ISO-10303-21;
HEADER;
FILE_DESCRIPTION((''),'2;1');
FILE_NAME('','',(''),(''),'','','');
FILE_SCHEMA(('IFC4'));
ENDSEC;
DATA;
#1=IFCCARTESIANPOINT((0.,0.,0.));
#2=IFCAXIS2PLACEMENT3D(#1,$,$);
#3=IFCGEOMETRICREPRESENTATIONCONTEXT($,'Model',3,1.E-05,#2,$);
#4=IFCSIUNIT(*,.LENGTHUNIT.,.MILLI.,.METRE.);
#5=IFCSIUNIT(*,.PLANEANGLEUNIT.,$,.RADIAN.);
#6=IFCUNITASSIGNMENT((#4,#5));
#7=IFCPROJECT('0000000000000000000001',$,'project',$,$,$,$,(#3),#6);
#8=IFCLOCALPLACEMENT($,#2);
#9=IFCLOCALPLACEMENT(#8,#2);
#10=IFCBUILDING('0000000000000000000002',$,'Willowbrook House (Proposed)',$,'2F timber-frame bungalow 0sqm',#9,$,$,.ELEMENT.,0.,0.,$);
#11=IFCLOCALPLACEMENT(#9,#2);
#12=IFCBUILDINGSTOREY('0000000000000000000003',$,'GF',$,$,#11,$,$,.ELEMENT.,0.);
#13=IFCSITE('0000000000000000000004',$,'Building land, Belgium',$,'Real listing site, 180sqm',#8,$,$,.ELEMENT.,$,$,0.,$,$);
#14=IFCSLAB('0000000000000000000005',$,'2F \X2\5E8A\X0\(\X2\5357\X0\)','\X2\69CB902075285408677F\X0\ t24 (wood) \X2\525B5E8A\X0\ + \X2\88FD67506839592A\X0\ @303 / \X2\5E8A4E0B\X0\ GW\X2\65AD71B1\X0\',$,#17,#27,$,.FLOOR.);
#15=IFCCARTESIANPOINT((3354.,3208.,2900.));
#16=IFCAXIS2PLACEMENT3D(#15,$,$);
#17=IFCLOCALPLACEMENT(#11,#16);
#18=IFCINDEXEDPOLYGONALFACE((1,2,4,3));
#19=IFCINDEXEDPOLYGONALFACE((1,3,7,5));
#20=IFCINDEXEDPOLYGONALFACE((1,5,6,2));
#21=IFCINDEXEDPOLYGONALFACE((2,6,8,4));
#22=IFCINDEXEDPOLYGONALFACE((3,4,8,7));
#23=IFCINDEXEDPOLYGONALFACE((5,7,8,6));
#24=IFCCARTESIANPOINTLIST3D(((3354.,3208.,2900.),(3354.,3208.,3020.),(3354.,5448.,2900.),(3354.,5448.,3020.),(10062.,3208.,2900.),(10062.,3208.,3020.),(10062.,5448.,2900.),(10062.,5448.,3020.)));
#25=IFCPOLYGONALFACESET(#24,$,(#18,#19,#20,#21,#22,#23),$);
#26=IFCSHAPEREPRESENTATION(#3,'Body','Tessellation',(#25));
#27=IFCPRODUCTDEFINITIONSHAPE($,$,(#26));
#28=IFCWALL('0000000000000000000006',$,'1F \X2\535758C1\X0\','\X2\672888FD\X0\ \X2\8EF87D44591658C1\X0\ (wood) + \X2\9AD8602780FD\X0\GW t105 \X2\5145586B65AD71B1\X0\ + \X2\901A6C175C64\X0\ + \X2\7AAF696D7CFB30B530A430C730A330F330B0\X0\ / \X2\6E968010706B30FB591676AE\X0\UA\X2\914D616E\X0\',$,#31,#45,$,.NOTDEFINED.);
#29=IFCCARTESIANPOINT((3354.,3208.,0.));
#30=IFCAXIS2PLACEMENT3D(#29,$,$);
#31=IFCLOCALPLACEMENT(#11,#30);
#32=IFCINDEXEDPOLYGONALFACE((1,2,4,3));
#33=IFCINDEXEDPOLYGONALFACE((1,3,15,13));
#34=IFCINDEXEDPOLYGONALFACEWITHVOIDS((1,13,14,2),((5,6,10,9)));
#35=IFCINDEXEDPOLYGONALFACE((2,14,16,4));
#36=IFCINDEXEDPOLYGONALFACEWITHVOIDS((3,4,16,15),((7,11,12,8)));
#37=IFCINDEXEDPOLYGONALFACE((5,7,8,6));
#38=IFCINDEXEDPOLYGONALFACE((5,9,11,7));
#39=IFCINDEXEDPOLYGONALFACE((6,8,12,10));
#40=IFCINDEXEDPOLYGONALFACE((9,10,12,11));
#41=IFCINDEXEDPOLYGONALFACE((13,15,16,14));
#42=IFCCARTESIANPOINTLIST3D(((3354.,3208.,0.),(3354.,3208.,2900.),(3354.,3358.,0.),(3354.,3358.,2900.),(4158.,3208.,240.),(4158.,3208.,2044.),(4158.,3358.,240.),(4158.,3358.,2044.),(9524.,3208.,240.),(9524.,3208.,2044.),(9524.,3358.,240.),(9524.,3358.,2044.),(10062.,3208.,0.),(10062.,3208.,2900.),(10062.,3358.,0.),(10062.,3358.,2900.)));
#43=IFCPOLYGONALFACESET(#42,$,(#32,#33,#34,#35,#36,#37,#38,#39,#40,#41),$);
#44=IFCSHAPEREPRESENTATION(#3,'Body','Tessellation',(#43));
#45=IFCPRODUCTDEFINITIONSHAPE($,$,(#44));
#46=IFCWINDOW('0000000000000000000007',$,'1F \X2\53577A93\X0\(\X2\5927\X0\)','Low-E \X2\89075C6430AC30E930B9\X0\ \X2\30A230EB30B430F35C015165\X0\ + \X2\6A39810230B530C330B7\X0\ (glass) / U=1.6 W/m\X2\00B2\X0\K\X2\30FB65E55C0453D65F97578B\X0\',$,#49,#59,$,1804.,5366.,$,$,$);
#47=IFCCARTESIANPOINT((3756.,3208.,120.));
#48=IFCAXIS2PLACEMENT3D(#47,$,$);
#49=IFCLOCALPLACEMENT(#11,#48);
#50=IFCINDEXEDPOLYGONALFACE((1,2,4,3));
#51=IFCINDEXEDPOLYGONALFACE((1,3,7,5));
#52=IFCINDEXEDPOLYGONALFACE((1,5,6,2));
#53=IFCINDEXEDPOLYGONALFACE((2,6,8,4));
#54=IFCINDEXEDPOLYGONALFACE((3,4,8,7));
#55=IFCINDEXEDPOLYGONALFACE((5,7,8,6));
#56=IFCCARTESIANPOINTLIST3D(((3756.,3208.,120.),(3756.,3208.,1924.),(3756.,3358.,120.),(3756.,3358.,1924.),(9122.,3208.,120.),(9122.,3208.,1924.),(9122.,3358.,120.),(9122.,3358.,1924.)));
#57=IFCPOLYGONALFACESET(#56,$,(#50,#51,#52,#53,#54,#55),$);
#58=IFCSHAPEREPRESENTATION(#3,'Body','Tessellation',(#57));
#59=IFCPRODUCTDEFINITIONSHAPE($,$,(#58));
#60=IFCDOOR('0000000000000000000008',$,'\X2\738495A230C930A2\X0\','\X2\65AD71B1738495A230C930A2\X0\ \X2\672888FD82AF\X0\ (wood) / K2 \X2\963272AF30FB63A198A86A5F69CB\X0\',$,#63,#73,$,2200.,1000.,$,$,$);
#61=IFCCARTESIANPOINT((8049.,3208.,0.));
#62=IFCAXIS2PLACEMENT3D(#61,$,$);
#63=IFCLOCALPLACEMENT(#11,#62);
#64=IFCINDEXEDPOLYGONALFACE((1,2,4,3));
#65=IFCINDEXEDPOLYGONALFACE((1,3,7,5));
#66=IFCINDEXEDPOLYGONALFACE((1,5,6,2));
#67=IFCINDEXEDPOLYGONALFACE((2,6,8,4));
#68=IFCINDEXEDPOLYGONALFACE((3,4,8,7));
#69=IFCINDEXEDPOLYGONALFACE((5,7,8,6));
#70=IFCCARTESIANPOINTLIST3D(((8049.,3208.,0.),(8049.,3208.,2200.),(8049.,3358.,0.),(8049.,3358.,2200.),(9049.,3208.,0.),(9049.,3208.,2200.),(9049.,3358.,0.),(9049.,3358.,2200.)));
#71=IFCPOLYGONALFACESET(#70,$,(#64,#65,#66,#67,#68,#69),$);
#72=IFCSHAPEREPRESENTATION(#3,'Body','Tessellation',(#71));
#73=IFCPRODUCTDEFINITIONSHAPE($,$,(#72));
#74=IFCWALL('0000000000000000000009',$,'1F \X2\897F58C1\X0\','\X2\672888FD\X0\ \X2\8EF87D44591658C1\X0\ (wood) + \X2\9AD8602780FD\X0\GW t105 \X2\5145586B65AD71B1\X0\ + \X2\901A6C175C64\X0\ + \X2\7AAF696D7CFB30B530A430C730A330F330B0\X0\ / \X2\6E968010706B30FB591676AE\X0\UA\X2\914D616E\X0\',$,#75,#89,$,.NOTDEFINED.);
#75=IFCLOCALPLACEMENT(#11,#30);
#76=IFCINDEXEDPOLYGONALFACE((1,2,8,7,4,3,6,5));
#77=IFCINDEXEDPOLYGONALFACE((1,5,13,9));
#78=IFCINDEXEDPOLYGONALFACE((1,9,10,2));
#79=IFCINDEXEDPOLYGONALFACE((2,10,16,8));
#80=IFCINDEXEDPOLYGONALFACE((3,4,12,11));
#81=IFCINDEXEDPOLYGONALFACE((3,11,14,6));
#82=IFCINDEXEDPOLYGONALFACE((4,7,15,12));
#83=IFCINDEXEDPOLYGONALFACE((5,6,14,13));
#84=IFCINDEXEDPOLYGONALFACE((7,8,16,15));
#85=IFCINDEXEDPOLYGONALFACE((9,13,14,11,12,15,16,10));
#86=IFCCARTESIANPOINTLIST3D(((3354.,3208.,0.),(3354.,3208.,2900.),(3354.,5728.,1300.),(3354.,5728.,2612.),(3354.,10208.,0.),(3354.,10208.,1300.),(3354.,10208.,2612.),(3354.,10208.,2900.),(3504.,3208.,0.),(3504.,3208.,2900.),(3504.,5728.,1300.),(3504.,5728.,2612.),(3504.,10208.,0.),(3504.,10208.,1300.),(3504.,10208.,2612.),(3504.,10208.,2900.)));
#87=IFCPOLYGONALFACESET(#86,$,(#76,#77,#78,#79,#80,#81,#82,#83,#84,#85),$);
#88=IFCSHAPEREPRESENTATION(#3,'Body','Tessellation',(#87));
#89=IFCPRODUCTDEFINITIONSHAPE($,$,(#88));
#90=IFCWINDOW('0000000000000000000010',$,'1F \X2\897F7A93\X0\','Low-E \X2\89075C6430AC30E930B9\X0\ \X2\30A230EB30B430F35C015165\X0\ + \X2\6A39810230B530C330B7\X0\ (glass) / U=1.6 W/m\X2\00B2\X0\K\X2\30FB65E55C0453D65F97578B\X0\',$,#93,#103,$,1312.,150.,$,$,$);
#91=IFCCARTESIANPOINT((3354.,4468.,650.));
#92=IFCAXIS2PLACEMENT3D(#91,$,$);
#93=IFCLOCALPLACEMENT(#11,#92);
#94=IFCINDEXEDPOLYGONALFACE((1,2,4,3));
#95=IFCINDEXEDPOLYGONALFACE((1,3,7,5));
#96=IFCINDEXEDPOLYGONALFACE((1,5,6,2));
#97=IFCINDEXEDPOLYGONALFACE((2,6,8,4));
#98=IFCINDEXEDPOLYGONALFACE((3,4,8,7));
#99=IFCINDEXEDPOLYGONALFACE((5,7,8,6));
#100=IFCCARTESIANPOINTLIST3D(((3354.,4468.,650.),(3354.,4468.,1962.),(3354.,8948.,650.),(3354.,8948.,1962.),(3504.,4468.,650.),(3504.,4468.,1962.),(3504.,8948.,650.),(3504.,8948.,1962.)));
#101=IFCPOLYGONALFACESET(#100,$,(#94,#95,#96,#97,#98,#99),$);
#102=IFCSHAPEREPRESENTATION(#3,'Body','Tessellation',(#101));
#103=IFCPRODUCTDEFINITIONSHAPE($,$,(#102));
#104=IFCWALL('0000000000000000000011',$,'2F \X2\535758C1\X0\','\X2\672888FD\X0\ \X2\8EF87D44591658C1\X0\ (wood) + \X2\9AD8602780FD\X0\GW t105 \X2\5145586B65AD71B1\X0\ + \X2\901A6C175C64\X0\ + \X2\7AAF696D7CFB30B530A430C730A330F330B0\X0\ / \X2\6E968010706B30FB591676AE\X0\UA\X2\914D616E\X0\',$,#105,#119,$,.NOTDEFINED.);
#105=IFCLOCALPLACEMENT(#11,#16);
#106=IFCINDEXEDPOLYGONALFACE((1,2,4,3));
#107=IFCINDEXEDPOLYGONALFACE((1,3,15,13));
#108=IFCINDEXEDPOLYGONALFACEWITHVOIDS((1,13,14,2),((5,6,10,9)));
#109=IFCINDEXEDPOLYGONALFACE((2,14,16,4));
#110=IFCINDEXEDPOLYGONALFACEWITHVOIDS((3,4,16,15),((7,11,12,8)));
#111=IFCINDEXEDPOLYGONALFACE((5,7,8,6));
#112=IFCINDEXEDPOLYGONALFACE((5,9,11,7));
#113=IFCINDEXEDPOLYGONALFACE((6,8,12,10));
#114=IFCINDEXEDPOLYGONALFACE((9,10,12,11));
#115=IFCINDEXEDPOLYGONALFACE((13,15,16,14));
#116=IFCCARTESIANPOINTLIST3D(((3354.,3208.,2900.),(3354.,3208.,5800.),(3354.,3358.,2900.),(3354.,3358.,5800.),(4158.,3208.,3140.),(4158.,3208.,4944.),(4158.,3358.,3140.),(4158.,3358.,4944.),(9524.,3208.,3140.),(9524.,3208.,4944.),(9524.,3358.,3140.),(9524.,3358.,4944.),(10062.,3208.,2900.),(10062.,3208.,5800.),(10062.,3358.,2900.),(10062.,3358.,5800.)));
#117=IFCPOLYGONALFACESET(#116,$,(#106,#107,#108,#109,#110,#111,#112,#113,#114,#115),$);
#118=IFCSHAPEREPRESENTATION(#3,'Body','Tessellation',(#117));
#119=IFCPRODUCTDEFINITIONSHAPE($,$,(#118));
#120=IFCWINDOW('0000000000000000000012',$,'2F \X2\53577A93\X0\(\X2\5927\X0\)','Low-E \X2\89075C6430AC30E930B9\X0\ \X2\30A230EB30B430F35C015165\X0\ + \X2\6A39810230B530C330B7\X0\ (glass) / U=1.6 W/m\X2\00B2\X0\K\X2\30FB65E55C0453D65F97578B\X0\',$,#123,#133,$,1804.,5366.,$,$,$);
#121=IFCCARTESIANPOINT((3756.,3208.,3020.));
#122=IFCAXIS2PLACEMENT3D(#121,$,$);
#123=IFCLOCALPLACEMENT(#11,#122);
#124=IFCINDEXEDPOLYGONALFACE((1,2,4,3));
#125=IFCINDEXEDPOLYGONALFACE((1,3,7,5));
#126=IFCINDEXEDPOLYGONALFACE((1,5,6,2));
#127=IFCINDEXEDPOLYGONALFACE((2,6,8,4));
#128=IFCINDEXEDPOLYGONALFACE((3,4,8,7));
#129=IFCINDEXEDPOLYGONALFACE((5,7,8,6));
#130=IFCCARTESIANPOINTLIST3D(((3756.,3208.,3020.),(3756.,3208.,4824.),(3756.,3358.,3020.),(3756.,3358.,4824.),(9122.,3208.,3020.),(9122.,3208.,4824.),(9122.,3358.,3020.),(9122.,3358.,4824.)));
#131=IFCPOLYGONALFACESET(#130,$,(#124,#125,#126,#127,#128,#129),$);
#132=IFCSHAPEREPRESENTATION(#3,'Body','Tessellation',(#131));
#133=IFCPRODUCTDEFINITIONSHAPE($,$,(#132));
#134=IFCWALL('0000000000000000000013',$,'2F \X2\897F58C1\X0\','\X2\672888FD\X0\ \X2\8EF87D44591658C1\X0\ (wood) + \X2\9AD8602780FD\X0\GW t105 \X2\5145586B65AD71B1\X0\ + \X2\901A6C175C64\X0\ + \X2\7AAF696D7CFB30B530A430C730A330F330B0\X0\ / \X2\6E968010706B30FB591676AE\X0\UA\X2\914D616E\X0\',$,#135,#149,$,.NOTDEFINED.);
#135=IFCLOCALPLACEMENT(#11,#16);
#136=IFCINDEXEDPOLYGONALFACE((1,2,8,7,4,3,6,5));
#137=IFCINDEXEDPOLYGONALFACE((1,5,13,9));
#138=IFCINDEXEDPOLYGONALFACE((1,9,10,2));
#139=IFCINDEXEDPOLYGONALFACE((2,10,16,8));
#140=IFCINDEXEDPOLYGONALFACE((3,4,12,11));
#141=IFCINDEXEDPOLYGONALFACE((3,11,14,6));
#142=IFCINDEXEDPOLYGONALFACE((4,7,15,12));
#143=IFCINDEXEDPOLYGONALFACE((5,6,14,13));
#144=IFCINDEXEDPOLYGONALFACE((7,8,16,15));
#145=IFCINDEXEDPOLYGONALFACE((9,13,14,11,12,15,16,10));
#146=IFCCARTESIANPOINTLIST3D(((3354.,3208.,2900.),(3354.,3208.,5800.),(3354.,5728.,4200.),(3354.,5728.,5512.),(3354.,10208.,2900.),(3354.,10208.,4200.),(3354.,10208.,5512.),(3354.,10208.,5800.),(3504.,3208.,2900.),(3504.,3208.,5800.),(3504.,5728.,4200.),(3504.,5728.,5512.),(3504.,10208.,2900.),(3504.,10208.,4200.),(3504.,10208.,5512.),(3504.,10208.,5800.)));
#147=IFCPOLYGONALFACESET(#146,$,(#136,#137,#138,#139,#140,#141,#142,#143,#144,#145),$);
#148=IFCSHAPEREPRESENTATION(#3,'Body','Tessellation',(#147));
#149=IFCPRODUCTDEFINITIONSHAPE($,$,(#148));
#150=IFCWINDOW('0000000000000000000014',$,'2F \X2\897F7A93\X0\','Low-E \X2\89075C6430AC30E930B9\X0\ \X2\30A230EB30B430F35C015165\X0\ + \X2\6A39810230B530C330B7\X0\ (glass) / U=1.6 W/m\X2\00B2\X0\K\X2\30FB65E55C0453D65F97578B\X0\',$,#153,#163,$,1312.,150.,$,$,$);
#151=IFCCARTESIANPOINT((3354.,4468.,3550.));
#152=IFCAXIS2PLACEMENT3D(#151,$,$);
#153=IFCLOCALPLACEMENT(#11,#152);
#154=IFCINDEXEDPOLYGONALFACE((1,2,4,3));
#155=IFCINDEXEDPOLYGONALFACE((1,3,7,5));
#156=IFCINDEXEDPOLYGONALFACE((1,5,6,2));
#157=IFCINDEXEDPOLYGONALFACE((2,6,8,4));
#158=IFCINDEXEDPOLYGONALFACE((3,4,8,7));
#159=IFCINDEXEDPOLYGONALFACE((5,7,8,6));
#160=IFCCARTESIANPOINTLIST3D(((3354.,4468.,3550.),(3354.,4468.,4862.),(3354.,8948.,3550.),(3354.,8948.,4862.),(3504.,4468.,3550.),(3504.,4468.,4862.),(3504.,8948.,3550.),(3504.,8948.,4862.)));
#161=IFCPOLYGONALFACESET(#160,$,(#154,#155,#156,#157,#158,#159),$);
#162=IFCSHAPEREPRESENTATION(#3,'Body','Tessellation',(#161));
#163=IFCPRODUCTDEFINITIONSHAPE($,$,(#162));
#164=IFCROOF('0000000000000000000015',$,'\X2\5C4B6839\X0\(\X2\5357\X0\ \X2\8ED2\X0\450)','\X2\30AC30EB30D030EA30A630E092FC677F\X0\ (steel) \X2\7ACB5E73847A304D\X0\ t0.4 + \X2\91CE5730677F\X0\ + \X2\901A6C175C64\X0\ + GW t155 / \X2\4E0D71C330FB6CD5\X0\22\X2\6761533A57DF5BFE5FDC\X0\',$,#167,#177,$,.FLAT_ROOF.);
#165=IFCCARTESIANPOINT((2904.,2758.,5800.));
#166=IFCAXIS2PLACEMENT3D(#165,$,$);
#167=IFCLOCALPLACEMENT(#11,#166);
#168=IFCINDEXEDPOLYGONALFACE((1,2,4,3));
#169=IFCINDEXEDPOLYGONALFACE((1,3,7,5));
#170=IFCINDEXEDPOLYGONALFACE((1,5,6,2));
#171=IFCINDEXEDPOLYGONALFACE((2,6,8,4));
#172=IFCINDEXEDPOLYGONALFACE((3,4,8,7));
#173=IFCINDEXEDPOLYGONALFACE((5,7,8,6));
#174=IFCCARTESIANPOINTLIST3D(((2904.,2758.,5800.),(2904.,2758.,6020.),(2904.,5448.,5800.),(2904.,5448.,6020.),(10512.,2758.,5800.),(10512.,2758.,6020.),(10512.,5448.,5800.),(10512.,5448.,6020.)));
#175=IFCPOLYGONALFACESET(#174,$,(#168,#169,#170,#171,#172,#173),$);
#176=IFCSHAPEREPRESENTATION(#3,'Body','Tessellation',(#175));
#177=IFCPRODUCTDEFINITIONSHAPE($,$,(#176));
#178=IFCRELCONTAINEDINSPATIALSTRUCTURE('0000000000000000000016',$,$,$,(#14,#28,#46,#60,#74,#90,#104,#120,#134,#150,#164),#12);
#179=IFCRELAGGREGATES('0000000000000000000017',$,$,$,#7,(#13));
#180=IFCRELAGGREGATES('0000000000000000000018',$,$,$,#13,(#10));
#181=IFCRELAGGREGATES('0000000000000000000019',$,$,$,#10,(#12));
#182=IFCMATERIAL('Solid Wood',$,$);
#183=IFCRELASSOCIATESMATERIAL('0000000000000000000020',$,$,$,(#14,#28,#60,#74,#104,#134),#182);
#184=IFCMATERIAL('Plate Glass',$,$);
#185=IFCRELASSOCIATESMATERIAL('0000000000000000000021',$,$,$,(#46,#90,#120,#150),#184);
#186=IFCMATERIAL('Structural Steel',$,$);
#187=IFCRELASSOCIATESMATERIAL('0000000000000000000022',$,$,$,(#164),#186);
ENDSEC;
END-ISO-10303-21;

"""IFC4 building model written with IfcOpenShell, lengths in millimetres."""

from ifc_helpers import new_model, si_unit, frame, frame_2d, origin, place, context, project, spatial, rectangle, extrude, material, element, fill, save


model = new_model("IFC4")

# Units and contexts
model_context = context("Model", 3, precision=1e-05, world=origin())
ifc_project = project(units=[si_unit("LENGTHUNIT", "METRE", prefix="MILLI"), si_unit("PLANEANGLEUNIT", "RADIAN")], contexts=[model_context])

# Site, building, storey
site_placement = place(None, origin())
site = spatial("IfcSite", under=ifc_project, at=site_placement, Name="Building land, Belgium", ObjectType="Real listing site, 180sqm", CompositionType="ELEMENT", RefElevation=0.0)
building_placement = place(site_placement, origin())
building = spatial("IfcBuilding", under=site, at=building_placement, Name="Willowbrook House (Proposed)", ObjectType="2F timber-frame bungalow 0sqm", CompositionType="ELEMENT", ElevationOfRefHeight=0.0, ElevationOfTerrain=0.0)
storey_placement = place(building_placement, origin())
storey = spatial("IfcBuildingStorey", under=building, at=storey_placement, Name="GF", CompositionType="ELEMENT", Elevation=0.0)

# Slab
ifc_material_1 = material(Name="Solid Wood")
slab_1_placement = place(storey_placement, frame((3354.0, 3208.0, 2900.0)))
element("IfcSlab", 1, at=slab_1_placement, inside=storey, material=ifc_material_1, Name="2F 床(南)", Description="構造用合板 t24 (wood) 剛床 + 製材根太 @303 / 床下 GW断熱", PredefinedType="FLOOR", context=model_context, shape_type="SweptSolid", body=[
    extrude(rectangle(XDim=6708.0, YDim=2240.0, at=frame_2d((3354.0, 1120.0))), frame((3354.0, 3208.0, 2900.0)), (0.0, 0.0, 1.0), 120.0),
])

# Wall, openings, window, door
wall_1_placement = place(storey_placement, frame((3354.0, 3208.0, 0.0)))
wall_1 = element("IfcWall", 2, at=wall_1_placement, inside=storey, material=ifc_material_1, Name="1F 南壁", Description="木製 軸組外壁 (wood) + 高性能GW t105 充填断熱 + 通気層 + 窯業系サイディング / 準耐火・外皮UA配慮", PredefinedType="NOTDEFINED", context=model_context, shape_type="SweptSolid", body=[
    extrude(rectangle(XDim=6708.0, YDim=150.0, at=frame_2d((3354.0, 75.0))), frame((3354.0, 3208.0, 0.0)), (0.0, 0.0, 1.0), 2900.0),
])
opening_1_placement = place(storey_placement, frame((3756.0, 3208.0, 120.0)))
opening_1 = element("IfcOpeningElement", 3, at=opening_1_placement, cuts=wall_1, PredefinedType="NOTDEFINED", context=model_context, shape_type="SweptSolid", body=[
    extrude(rectangle(XDim=5366.0, YDim=150.0, at=frame_2d((2683.0, 75.0))), frame((3756.0, 3208.0, 120.0)), (0.0, 0.0, 1.0), 1804.0),
])
opening_2_placement = place(storey_placement, frame((8049.0, 3208.0, 0.0)))
opening_2 = element("IfcOpeningElement", 4, at=opening_2_placement, cuts=wall_1, PredefinedType="NOTDEFINED", context=model_context, shape_type="SweptSolid", body=[
    extrude(rectangle(XDim=1000.0, YDim=150.0, at=frame_2d((500.0, 75.0))), frame((8049.0, 3208.0, 0.0)), (0.0, 0.0, 1.0), 2200.0),
])
ifc_material_2 = material(Name="Plate Glass")
window_1_placement = place(storey_placement, frame((3756.0, 3208.0, 120.0)))
window_1 = element("IfcWindow", 5, at=window_1_placement, inside=storey, material=ifc_material_2, Name="1F 南窓(大)", Description="Low-E 複層ガラス アルゴン封入 + 樹脂サッシ (glass) / U=1.6 W/m²K・日射取得型", OverallHeight=1804.0, OverallWidth=5366.0, context=model_context, shape_type="SweptSolid", body=[
    extrude(rectangle(XDim=5366.0, YDim=150.0, at=frame_2d((2683.0, 75.0))), frame((3756.0, 3208.0, 120.0)), (0.0, 0.0, 1.0), 1804.0),
])
fill(opening_1, window_1)
door_placement = place(storey_placement, frame((8049.0, 3208.0, 0.0)))
door = element("IfcDoor", 6, at=door_placement, inside=storey, material=ifc_material_1, Name="玄関ドア", Description="断熱玄関ドア 木製芯 (wood) / K2 防犯・採風機構", OverallHeight=2200.0, OverallWidth=1000.0, context=model_context, shape_type="SweptSolid", body=[
    extrude(rectangle(XDim=1000.0, YDim=150.0, at=frame_2d((500.0, 75.0))), frame((8049.0, 3208.0, 0.0)), (0.0, 0.0, 1.0), 2200.0),
])
fill(opening_2, door)

# Walls, openings, windows
wall_2_placement = place(storey_placement, frame((3354.0, 3208.0, 0.0)))
wall_2 = element("IfcWall", 7, at=wall_2_placement, inside=storey, material=ifc_material_1, Name="1F 西壁", Description="木製 軸組外壁 (wood) + 高性能GW t105 充填断熱 + 通気層 + 窯業系サイディング / 準耐火・外皮UA配慮", PredefinedType="NOTDEFINED", context=model_context, shape_type="SweptSolid", body=[
    extrude(rectangle(XDim=150.0, YDim=7000.0, at=frame_2d((75.0, 3500.0))), frame((3354.0, 3208.0, 0.0)), (0.0, 0.0, 1.0), 2900.0),
])
opening_3_placement = place(storey_placement, frame((3354.0, 4468.0, 650.0)))
opening_3 = element("IfcOpeningElement", 8, at=opening_3_placement, cuts=wall_2, PredefinedType="NOTDEFINED", context=model_context, shape_type="SweptSolid", body=[
    extrude(rectangle(XDim=150.0, YDim=4480.0, at=frame_2d((75.0, 2240.0))), frame((3354.0, 4468.0, 650.0)), (0.0, 0.0, 1.0), 1312.0),
])
window_2_placement = place(storey_placement, frame((3354.0, 4468.0, 650.0)))
window_2 = element("IfcWindow", 9, at=window_2_placement, inside=storey, material=ifc_material_2, Name="1F 西窓", Description="Low-E 複層ガラス アルゴン封入 + 樹脂サッシ (glass) / U=1.6 W/m²K・日射取得型", OverallHeight=1312.0, OverallWidth=150.0, context=model_context, shape_type="SweptSolid", body=[
    extrude(rectangle(XDim=150.0, YDim=4480.0, at=frame_2d((75.0, 2240.0))), frame((3354.0, 4468.0, 650.0)), (0.0, 0.0, 1.0), 1312.0),
])
fill(opening_3, window_2)
wall_3_placement = place(storey_placement, frame((3354.0, 3208.0, 2900.0)))
wall_3 = element("IfcWall", 10, at=wall_3_placement, inside=storey, material=ifc_material_1, Name="2F 南壁", Description="木製 軸組外壁 (wood) + 高性能GW t105 充填断熱 + 通気層 + 窯業系サイディング / 準耐火・外皮UA配慮", PredefinedType="NOTDEFINED", context=model_context, shape_type="SweptSolid", body=[
    extrude(rectangle(XDim=6708.0, YDim=150.0, at=frame_2d((3354.0, 75.0))), frame((3354.0, 3208.0, 2900.0)), (0.0, 0.0, 1.0), 2900.0),
])
opening_4_placement = place(storey_placement, frame((3756.0, 3208.0, 3020.0)))
opening_4 = element("IfcOpeningElement", 11, at=opening_4_placement, cuts=wall_3, PredefinedType="NOTDEFINED", context=model_context, shape_type="SweptSolid", body=[
    extrude(rectangle(XDim=5366.0, YDim=150.0, at=frame_2d((2683.0, 75.0))), frame((3756.0, 3208.0, 3020.0)), (0.0, 0.0, 1.0), 1804.0),
])
window_3_placement = place(storey_placement, frame((3756.0, 3208.0, 3020.0)))
window_3 = element("IfcWindow", 12, at=window_3_placement, inside=storey, material=ifc_material_2, Name="2F 南窓(大)", Description="Low-E 複層ガラス アルゴン封入 + 樹脂サッシ (glass) / U=1.6 W/m²K・日射取得型", OverallHeight=1804.0, OverallWidth=5366.0, context=model_context, shape_type="SweptSolid", body=[
    extrude(rectangle(XDim=5366.0, YDim=150.0, at=frame_2d((2683.0, 75.0))), frame((3756.0, 3208.0, 3020.0)), (0.0, 0.0, 1.0), 1804.0),
])
fill(opening_4, window_3)
wall_4_placement = place(storey_placement, frame((3354.0, 3208.0, 2900.0)))
wall_4 = element("IfcWall", 13, at=wall_4_placement, inside=storey, material=ifc_material_1, Name="2F 西壁", Description="木製 軸組外壁 (wood) + 高性能GW t105 充填断熱 + 通気層 + 窯業系サイディング / 準耐火・外皮UA配慮", PredefinedType="NOTDEFINED", context=model_context, shape_type="SweptSolid", body=[
    extrude(rectangle(XDim=150.0, YDim=7000.0, at=frame_2d((75.0, 3500.0))), frame((3354.0, 3208.0, 2900.0)), (0.0, 0.0, 1.0), 2900.0),
])
opening_5_placement = place(storey_placement, frame((3354.0, 4468.0, 3550.0)))
opening_5 = element("IfcOpeningElement", 14, at=opening_5_placement, cuts=wall_4, PredefinedType="NOTDEFINED", context=model_context, shape_type="SweptSolid", body=[
    extrude(rectangle(XDim=150.0, YDim=4480.0, at=frame_2d((75.0, 2240.0))), frame((3354.0, 4468.0, 3550.0)), (0.0, 0.0, 1.0), 1312.0),
])
window_4_placement = place(storey_placement, frame((3354.0, 4468.0, 3550.0)))
window_4 = element("IfcWindow", 15, at=window_4_placement, inside=storey, material=ifc_material_2, Name="2F 西窓", Description="Low-E 複層ガラス アルゴン封入 + 樹脂サッシ (glass) / U=1.6 W/m²K・日射取得型", OverallHeight=1312.0, OverallWidth=150.0, context=model_context, shape_type="SweptSolid", body=[
    extrude(rectangle(XDim=150.0, YDim=4480.0, at=frame_2d((75.0, 2240.0))), frame((3354.0, 4468.0, 3550.0)), (0.0, 0.0, 1.0), 1312.0),
])
fill(opening_5, window_4)

# Roof
ifc_material_3 = material(Name="Structural Steel")
roof_1_placement = place(storey_placement, frame((2904.0, 2758.0, 5800.0)))
element("IfcRoof", 16, at=roof_1_placement, inside=storey, material=ifc_material_3, Name="屋根(南 軒450)", Description="ガルバリウム鋼板 (steel) 立平葺き t0.4 + 野地板 + 通気層 + GW t155 / 不燃・法22条区域対応", PredefinedType="FLAT_ROOF", context=model_context, shape_type="SweptSolid", body=[
    extrude(rectangle(XDim=7608.0, YDim=2690.0, at=frame_2d((3804.0, 1345.0))), frame((2904.0, 2758.0, 5800.0)), (0.0, 0.0, 1.0), 220.0),
])

save(model, "model.ifc")
